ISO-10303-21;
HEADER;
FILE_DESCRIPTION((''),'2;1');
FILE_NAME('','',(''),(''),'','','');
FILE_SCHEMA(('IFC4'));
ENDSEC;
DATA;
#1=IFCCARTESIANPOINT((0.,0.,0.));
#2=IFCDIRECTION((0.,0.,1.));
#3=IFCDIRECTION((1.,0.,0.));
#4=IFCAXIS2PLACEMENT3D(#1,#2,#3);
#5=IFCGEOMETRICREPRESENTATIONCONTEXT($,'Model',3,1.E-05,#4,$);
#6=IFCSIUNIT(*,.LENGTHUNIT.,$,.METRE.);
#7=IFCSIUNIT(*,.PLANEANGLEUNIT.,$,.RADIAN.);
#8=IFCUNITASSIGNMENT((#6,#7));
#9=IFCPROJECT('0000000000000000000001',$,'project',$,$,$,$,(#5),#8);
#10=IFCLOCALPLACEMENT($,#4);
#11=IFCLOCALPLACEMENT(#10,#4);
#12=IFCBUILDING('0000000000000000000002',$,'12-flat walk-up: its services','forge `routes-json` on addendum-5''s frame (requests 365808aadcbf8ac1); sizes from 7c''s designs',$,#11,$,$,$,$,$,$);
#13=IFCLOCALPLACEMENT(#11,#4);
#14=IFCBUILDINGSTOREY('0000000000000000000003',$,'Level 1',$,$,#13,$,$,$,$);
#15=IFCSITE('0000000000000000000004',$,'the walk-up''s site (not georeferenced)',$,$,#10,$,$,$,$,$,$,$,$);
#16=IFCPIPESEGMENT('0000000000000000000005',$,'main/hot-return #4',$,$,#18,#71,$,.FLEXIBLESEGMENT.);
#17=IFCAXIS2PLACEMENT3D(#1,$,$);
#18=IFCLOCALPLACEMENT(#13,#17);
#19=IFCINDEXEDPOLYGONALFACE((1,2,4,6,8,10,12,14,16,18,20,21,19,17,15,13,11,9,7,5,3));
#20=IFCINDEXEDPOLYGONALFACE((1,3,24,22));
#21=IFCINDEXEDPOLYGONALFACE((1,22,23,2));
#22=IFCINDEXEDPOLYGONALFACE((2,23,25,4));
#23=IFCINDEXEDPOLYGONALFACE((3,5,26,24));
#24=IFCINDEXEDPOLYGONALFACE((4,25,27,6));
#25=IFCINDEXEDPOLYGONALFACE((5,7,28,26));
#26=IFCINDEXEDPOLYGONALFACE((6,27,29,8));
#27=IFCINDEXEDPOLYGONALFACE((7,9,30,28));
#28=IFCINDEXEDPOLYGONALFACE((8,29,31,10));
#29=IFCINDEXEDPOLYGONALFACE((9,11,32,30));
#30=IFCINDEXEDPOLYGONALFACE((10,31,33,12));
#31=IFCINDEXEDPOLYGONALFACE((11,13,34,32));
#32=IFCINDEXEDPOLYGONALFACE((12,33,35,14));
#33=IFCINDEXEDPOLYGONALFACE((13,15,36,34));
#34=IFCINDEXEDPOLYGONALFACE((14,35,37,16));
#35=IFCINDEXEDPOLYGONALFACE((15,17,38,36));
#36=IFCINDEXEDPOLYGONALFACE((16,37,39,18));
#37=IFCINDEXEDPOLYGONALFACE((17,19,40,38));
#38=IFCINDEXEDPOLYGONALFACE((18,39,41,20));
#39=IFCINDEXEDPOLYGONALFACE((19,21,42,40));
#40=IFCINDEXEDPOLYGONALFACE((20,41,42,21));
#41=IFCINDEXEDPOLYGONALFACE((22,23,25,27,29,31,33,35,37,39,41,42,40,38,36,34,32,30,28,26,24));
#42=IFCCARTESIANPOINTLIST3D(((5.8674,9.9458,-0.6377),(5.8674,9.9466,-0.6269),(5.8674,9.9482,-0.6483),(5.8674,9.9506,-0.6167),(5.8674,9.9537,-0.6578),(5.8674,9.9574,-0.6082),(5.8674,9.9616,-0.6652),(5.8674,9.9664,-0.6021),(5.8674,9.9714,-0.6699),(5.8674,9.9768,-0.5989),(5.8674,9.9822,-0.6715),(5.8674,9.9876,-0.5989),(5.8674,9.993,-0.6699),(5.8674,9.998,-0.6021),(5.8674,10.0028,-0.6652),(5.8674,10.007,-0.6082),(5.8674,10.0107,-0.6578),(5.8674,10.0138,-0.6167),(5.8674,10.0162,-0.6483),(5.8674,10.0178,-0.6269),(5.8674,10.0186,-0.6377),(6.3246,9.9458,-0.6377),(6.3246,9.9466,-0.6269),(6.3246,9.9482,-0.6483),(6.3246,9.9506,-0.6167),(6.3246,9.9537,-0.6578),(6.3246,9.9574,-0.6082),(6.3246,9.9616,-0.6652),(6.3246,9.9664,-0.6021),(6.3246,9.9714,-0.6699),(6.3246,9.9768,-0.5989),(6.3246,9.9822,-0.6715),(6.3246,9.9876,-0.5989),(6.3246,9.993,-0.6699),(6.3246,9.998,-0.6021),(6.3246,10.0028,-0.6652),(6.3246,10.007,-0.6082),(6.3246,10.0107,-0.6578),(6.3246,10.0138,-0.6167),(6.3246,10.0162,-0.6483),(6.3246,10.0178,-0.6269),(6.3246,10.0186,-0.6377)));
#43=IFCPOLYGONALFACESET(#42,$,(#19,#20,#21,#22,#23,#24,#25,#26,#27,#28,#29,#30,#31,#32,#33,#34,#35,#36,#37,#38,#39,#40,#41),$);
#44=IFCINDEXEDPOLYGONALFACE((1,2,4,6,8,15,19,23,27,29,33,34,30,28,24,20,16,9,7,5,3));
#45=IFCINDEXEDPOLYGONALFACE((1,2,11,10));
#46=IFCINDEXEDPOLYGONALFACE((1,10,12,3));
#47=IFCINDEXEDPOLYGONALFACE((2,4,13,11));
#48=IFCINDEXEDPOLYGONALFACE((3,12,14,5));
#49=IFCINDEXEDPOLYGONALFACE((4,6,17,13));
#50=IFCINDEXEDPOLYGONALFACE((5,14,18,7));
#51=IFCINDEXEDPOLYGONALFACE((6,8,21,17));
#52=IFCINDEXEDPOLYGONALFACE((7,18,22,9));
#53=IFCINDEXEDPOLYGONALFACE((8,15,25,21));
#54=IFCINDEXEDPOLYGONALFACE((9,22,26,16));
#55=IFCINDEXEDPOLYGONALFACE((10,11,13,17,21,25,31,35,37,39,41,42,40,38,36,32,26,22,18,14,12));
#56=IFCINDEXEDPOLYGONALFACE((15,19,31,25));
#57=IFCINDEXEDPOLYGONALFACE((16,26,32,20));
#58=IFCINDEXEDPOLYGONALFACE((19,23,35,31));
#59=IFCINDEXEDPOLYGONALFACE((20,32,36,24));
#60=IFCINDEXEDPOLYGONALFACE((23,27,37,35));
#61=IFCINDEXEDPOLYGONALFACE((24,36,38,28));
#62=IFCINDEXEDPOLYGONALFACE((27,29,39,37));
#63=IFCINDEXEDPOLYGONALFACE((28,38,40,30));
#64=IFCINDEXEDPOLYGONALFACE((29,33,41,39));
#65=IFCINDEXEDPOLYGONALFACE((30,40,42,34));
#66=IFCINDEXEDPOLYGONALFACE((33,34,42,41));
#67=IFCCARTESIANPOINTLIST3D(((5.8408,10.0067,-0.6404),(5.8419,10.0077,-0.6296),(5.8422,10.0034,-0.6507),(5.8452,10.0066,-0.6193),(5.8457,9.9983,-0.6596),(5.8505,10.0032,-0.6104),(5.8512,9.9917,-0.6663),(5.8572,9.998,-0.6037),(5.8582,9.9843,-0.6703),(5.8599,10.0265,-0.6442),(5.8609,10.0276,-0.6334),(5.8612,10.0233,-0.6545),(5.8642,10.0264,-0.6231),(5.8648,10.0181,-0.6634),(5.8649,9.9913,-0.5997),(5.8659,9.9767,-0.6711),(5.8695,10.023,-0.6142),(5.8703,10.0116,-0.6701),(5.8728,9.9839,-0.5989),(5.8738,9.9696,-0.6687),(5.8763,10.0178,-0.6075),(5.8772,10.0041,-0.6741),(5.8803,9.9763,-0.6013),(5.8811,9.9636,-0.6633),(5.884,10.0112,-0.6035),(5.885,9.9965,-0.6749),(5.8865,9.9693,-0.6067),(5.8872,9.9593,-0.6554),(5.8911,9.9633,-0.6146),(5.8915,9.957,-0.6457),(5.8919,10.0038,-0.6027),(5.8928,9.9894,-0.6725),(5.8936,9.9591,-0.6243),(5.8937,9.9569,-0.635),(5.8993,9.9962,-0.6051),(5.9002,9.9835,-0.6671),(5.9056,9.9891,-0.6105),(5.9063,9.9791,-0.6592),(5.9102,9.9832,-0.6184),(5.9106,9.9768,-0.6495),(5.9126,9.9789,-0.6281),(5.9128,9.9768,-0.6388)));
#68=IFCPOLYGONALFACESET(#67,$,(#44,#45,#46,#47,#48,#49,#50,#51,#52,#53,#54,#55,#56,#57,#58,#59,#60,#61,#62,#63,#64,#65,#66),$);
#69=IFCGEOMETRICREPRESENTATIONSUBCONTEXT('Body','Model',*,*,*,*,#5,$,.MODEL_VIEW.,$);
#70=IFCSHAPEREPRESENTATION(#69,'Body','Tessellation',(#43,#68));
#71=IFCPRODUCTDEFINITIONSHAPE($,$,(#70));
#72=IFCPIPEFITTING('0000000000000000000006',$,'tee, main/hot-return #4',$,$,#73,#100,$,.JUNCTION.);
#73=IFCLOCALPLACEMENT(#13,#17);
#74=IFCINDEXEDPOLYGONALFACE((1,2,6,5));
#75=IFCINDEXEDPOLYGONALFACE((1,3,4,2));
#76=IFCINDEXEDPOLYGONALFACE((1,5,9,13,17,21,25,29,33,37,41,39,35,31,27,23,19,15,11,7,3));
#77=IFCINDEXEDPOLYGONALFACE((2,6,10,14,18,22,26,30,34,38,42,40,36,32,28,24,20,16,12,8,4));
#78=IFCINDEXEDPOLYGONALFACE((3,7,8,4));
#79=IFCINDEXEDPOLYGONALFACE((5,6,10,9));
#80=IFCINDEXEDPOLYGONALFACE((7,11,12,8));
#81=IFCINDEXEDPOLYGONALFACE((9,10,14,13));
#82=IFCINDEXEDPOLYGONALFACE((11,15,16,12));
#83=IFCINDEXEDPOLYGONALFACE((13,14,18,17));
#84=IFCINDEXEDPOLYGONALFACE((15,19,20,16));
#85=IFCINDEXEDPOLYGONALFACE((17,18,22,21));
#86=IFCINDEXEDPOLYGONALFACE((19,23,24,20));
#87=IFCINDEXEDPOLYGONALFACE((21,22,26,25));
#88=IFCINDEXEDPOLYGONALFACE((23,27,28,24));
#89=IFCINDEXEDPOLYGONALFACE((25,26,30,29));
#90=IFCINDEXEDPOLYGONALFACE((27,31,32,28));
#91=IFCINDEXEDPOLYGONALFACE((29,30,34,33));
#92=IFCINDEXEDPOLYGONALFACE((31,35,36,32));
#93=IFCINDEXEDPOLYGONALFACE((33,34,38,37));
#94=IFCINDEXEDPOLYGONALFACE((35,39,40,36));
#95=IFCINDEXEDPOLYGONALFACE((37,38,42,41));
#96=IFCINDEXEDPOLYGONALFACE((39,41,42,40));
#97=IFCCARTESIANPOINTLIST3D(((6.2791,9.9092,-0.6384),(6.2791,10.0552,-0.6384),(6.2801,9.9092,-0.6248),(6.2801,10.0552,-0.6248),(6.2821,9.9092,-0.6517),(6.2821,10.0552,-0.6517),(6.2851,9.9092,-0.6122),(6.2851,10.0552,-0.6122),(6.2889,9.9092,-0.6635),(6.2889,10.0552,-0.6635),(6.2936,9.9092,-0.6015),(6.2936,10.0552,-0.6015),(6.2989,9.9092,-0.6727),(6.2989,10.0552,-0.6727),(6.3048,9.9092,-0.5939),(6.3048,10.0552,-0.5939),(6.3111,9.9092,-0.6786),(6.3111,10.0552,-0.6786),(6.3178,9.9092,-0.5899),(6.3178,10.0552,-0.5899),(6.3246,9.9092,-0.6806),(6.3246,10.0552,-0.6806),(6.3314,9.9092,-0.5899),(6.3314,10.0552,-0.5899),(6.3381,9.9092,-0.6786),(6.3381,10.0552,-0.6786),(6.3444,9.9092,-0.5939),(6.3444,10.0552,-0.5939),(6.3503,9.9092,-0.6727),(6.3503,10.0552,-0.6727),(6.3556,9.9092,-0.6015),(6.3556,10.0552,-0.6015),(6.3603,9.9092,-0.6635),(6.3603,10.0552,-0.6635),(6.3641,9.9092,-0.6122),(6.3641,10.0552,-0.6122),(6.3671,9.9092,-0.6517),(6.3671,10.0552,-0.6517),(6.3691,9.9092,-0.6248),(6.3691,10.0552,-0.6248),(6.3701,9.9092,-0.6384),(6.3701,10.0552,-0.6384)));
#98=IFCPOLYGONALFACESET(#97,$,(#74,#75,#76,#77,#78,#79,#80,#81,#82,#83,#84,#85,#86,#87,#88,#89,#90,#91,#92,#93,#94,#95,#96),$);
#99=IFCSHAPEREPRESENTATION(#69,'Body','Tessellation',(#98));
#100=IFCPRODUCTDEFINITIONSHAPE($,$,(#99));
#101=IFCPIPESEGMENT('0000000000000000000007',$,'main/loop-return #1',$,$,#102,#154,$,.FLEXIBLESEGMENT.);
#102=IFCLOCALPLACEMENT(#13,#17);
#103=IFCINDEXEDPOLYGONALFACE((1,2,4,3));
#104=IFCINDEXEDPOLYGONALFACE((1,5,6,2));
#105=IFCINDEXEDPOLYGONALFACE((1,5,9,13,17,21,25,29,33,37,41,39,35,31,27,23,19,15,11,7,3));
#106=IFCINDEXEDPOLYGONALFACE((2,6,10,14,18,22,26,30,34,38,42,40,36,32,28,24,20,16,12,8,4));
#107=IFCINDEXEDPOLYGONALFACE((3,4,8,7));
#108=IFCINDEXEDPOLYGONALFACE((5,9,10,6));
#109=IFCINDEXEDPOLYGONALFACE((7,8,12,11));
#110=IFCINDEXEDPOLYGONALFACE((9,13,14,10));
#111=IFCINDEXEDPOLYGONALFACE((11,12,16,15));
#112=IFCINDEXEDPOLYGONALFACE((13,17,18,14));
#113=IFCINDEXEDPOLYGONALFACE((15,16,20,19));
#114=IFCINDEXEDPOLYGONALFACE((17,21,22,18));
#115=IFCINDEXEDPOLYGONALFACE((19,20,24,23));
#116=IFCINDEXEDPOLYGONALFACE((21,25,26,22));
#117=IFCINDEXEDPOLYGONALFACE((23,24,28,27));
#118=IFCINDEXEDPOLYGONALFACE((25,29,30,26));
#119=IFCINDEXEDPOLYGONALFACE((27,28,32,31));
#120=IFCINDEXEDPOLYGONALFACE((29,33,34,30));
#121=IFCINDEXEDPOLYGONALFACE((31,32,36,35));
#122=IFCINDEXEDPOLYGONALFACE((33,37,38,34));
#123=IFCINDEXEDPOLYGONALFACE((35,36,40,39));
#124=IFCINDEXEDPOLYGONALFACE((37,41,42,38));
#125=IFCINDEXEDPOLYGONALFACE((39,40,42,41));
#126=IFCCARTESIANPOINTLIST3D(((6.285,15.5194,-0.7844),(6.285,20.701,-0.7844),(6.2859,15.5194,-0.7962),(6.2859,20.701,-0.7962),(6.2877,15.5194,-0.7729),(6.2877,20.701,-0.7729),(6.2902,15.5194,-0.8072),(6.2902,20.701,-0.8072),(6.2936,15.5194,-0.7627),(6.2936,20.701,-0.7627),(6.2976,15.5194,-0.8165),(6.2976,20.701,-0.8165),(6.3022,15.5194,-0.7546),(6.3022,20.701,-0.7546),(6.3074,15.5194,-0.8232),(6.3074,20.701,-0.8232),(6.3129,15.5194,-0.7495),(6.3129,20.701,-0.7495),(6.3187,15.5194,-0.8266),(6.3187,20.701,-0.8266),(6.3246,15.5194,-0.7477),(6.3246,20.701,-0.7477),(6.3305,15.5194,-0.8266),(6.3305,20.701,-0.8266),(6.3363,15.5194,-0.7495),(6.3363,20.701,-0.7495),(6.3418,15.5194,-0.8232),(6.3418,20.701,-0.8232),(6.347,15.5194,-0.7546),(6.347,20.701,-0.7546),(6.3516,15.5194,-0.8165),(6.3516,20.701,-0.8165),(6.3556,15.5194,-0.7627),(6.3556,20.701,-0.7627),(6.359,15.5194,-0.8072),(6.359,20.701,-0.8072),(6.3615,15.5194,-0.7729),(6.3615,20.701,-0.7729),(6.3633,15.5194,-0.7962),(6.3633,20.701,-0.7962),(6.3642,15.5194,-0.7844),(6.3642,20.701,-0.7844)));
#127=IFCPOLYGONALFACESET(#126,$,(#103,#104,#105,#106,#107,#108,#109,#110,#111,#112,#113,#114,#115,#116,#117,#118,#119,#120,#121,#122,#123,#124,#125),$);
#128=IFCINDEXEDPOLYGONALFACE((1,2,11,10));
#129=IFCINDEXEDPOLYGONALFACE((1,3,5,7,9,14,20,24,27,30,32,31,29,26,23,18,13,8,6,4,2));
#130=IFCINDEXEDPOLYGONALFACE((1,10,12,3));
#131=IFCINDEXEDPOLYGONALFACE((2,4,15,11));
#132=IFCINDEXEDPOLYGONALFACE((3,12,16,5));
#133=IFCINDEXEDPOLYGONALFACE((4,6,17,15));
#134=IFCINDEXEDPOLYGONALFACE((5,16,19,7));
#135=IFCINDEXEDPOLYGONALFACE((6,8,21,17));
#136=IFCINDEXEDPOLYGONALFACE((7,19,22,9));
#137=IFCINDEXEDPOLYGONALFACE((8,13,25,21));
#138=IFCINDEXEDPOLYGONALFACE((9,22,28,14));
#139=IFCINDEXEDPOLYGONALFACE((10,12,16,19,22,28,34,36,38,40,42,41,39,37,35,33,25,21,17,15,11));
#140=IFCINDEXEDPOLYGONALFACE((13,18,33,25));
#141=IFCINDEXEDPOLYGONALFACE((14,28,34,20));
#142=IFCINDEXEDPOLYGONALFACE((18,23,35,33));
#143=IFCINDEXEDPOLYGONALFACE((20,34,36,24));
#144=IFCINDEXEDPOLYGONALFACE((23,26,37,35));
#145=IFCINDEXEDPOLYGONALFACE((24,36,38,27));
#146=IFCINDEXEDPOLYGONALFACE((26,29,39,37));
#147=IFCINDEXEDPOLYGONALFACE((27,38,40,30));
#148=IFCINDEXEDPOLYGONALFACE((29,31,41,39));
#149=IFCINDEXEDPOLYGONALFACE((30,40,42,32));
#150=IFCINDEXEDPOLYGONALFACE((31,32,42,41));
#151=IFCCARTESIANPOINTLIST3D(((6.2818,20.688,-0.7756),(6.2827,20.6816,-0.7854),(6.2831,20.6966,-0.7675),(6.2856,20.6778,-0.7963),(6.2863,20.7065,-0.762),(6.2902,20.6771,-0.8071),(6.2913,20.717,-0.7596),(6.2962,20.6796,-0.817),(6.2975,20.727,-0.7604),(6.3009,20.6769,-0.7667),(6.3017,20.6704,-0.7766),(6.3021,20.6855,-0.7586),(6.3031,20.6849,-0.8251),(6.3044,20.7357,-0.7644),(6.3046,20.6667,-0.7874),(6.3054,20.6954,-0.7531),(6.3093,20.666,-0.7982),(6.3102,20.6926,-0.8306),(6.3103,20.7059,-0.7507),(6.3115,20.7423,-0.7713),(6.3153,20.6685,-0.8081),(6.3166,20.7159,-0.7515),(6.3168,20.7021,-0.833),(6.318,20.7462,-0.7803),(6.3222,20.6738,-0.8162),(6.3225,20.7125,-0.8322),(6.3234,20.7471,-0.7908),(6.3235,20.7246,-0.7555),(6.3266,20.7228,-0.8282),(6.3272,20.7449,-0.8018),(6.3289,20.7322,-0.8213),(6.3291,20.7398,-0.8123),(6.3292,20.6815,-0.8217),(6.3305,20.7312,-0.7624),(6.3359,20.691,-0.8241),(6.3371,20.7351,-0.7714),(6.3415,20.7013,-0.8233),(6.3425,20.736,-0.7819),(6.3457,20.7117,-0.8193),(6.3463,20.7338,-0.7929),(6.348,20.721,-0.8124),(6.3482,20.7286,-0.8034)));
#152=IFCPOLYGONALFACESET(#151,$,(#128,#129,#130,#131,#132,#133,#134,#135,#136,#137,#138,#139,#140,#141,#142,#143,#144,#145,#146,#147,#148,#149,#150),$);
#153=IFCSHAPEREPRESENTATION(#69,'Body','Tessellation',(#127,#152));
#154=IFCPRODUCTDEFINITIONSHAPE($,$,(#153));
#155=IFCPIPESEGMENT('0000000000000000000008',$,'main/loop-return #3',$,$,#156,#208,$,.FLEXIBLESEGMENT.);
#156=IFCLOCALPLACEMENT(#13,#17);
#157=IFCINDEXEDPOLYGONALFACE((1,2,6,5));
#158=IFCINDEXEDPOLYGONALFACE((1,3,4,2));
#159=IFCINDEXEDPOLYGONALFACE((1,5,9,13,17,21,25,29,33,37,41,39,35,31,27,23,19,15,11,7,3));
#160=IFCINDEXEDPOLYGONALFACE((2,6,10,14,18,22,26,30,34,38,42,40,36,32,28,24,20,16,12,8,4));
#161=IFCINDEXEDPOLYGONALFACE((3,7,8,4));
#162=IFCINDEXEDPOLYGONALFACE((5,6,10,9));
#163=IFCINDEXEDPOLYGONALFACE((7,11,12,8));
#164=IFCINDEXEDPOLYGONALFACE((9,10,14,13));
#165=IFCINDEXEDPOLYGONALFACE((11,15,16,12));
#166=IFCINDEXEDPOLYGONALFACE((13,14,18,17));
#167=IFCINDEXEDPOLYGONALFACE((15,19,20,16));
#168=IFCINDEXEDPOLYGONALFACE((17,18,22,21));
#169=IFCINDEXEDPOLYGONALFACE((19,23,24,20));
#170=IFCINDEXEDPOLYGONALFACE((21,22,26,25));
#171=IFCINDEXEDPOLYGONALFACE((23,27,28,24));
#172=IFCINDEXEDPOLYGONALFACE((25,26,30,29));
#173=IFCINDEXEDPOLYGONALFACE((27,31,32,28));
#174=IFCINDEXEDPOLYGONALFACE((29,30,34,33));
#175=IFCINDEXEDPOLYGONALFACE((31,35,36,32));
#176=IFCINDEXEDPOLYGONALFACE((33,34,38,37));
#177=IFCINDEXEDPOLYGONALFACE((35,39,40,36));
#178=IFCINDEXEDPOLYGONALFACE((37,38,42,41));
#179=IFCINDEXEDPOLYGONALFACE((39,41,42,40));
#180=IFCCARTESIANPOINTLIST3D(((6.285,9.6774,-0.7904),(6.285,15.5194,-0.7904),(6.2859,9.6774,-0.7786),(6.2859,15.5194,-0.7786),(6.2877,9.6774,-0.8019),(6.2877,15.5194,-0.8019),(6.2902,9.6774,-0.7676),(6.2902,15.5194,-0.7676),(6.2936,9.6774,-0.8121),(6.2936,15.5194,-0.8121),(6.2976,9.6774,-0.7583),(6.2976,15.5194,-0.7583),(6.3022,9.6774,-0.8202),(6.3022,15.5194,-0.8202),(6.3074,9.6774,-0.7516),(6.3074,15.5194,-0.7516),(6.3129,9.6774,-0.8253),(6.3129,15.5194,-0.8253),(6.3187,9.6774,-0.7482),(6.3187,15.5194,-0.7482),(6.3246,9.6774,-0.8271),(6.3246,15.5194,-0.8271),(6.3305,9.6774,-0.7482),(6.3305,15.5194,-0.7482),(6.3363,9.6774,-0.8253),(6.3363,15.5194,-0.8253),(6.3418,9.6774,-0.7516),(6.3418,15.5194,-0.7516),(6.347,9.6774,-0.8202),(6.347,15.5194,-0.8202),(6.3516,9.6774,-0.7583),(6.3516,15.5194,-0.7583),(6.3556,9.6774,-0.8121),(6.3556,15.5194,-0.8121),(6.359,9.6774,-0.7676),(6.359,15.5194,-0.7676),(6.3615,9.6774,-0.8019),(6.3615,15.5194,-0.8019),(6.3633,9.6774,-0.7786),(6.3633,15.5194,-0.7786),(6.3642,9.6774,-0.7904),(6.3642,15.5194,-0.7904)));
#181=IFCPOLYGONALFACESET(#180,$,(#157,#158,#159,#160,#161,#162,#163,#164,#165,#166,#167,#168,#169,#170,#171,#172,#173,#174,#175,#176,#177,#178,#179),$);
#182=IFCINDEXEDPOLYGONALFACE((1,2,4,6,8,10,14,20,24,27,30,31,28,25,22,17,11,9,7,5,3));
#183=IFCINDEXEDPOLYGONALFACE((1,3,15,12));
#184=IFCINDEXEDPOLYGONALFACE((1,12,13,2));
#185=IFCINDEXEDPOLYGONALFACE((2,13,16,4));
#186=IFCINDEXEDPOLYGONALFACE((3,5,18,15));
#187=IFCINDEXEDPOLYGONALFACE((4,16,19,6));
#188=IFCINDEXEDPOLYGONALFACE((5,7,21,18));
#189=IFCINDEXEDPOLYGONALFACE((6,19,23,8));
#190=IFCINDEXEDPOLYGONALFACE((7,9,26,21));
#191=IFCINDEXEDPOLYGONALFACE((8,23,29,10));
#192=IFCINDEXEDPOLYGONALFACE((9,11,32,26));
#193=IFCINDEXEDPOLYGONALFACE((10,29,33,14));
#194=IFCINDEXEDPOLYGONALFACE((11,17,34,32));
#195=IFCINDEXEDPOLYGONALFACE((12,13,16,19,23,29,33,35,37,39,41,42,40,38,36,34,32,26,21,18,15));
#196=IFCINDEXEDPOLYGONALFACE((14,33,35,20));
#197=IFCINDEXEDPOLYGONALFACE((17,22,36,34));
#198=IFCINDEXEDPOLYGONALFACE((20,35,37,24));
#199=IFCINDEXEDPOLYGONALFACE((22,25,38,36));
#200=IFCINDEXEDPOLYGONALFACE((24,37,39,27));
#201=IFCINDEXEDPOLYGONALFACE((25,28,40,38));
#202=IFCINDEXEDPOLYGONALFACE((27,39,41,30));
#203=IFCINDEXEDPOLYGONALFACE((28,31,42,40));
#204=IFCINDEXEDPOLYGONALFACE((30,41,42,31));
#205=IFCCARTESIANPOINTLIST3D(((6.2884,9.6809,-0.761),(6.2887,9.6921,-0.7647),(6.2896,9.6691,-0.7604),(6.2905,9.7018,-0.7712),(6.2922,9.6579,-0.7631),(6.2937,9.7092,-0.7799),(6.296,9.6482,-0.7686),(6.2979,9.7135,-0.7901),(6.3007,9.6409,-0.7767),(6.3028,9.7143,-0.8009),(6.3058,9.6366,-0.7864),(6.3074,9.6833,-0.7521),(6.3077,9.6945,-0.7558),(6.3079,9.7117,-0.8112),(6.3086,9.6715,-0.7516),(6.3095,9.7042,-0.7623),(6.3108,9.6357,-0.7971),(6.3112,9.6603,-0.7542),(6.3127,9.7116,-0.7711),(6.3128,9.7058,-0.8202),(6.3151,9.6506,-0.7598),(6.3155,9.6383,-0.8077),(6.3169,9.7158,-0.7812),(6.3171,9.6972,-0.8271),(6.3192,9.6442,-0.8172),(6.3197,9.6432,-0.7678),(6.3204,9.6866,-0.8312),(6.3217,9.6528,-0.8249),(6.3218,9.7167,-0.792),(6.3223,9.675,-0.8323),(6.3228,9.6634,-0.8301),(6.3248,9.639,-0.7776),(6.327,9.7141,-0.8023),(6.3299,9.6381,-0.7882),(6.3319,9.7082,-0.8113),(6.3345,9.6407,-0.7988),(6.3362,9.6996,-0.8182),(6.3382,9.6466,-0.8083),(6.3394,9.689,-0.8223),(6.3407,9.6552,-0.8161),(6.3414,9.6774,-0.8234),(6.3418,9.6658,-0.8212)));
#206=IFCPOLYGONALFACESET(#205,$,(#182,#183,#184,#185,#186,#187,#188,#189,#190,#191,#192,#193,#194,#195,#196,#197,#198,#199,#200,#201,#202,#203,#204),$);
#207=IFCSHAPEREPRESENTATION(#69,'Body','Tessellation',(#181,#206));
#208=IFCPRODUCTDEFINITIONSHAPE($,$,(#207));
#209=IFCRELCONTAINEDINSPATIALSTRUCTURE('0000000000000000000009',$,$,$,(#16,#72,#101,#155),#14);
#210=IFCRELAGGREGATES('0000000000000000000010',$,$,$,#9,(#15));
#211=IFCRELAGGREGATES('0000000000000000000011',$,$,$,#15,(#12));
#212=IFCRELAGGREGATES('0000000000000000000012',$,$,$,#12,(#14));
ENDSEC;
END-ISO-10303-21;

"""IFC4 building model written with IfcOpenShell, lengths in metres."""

from ifc_helpers import new_model, entity, si_unit, frame, origin_with_axes, place, context, subcontext, project, spatial, element, save


model = new_model("IFC4")

# Units and contexts
model_context = context("Model", 3, precision=1e-05, world=origin_with_axes())
body_context = subcontext(model_context, "Body", "Model", "MODEL_VIEW")
ifc_project = project(units=[si_unit("LENGTHUNIT", "METRE"), si_unit("PLANEANGLEUNIT", "RADIAN")], contexts=[model_context])

# Site, building, storey
site_placement = place(None, origin_with_axes())
site = spatial("IfcSite", under=ifc_project, at=site_placement, Name="the walk-up's site (not georeferenced)")
building_placement = place(site_placement, origin_with_axes())
building = spatial("IfcBuilding", under=site, at=building_placement, Name="12-flat walk-up: its services", Description="forge `routes-json` on addendum-5's frame (requests 365808aadcbf8ac1); sizes from 7c's designs")
storey_placement = place(building_placement, origin_with_axes())
storey = spatial("IfcBuildingStorey", under=building, at=storey_placement, Name="Level 1")

# Pipe segment
pipe_segment_1_placement = place(storey_placement, frame((6.3246, 9.9822, -0.635), z_axis=(0.0, 0.0, 1.0), x_axis=(1.0, 0.0, 0.0)))
element("IfcPipeSegment", 1, at=pipe_segment_1_placement, inside=storey, Name="main/hot-return #4", PredefinedType="FLEXIBLESEGMENT", context=body_context, shape_type="AdvancedSweptSolid", body=[
    entity("IfcSweptDiskSolid", entity("IfcPolyline", [entity("IfcCartesianPoint", [0.0, 0.0, 0.0]), entity("IfcCartesianPoint", [-0.4572, 0.0, 0.0])]), 0.0365),
    entity("IfcSweptDiskSolid", entity("IfcPolyline", [entity("IfcCartesianPoint", [-0.4572, 0.0, 0.0]), entity("IfcCartesianPoint", [-0.4381, 0.0198, -0.0038])]), 0.0365),
])

# Pipe fitting
pipe_fitting_1_placement = place(storey_placement, frame((6.3246, 10.0552, -0.635), z_axis=(0.0, 0.0, 1.0), x_axis=(1.0, 0.0, 0.0)))
element("IfcPipeFitting", 2, at=pipe_fitting_1_placement, inside=storey, Name="tee, main/hot-return #4", PredefinedType="JUNCTION", context=body_context, shape_type="AdvancedSweptSolid", body=[
    entity("IfcSweptDiskSolid", entity("IfcPolyline", [entity("IfcCartesianPoint", [0.0, 0.0, 0.0]), entity("IfcCartesianPoint", [0.0, -0.146, 0.0])]), 0.0456),
])

# Pipe segments
pipe_segment_2_placement = place(storey_placement, frame((6.3246, 15.5194, -0.7874), z_axis=(0.0, 0.0, 1.0), x_axis=(1.0, 0.0, 0.0)))
element("IfcPipeSegment", 3, at=pipe_segment_2_placement, inside=storey, Name="main/loop-return #1", PredefinedType="FLEXIBLESEGMENT", context=body_context, shape_type="AdvancedSweptSolid", body=[
    entity("IfcSweptDiskSolid", entity("IfcPolyline", [entity("IfcCartesianPoint", [0.0, 0.0, 0.0]), entity("IfcCartesianPoint", [0.0, 5.1816, 0.0])]), 0.0397),
    entity("IfcSweptDiskSolid", entity("IfcPolyline", [entity("IfcCartesianPoint", [0.0, 5.1816, 0.0]), entity("IfcCartesianPoint", [-0.019, 5.1927, -0.0089])]), 0.0397),
])
pipe_segment_3_placement = place(storey_placement, frame((6.3246, 15.5194, -0.7874), z_axis=(0.0, 0.0, 1.0), x_axis=(1.0, 0.0, 0.0)))
element("IfcPipeSegment", 4, at=pipe_segment_3_placement, inside=storey, Name="main/loop-return #3", PredefinedType="FLEXIBLESEGMENT", context=body_context, shape_type="AdvancedSweptSolid", body=[
    entity("IfcSweptDiskSolid", entity("IfcPolyline", [entity("IfcCartesianPoint", [0.0, 0.0, 0.0]), entity("IfcCartesianPoint", [0.0, -5.842, 0.0])]), 0.0397),
    entity("IfcSweptDiskSolid", entity("IfcPolyline", [entity("IfcCartesianPoint", [0.0, -5.842, 0.0]), entity("IfcCartesianPoint", [-0.019, -5.8444, -0.0089])]), 0.0397),
])

save(model, "model.ifc")
